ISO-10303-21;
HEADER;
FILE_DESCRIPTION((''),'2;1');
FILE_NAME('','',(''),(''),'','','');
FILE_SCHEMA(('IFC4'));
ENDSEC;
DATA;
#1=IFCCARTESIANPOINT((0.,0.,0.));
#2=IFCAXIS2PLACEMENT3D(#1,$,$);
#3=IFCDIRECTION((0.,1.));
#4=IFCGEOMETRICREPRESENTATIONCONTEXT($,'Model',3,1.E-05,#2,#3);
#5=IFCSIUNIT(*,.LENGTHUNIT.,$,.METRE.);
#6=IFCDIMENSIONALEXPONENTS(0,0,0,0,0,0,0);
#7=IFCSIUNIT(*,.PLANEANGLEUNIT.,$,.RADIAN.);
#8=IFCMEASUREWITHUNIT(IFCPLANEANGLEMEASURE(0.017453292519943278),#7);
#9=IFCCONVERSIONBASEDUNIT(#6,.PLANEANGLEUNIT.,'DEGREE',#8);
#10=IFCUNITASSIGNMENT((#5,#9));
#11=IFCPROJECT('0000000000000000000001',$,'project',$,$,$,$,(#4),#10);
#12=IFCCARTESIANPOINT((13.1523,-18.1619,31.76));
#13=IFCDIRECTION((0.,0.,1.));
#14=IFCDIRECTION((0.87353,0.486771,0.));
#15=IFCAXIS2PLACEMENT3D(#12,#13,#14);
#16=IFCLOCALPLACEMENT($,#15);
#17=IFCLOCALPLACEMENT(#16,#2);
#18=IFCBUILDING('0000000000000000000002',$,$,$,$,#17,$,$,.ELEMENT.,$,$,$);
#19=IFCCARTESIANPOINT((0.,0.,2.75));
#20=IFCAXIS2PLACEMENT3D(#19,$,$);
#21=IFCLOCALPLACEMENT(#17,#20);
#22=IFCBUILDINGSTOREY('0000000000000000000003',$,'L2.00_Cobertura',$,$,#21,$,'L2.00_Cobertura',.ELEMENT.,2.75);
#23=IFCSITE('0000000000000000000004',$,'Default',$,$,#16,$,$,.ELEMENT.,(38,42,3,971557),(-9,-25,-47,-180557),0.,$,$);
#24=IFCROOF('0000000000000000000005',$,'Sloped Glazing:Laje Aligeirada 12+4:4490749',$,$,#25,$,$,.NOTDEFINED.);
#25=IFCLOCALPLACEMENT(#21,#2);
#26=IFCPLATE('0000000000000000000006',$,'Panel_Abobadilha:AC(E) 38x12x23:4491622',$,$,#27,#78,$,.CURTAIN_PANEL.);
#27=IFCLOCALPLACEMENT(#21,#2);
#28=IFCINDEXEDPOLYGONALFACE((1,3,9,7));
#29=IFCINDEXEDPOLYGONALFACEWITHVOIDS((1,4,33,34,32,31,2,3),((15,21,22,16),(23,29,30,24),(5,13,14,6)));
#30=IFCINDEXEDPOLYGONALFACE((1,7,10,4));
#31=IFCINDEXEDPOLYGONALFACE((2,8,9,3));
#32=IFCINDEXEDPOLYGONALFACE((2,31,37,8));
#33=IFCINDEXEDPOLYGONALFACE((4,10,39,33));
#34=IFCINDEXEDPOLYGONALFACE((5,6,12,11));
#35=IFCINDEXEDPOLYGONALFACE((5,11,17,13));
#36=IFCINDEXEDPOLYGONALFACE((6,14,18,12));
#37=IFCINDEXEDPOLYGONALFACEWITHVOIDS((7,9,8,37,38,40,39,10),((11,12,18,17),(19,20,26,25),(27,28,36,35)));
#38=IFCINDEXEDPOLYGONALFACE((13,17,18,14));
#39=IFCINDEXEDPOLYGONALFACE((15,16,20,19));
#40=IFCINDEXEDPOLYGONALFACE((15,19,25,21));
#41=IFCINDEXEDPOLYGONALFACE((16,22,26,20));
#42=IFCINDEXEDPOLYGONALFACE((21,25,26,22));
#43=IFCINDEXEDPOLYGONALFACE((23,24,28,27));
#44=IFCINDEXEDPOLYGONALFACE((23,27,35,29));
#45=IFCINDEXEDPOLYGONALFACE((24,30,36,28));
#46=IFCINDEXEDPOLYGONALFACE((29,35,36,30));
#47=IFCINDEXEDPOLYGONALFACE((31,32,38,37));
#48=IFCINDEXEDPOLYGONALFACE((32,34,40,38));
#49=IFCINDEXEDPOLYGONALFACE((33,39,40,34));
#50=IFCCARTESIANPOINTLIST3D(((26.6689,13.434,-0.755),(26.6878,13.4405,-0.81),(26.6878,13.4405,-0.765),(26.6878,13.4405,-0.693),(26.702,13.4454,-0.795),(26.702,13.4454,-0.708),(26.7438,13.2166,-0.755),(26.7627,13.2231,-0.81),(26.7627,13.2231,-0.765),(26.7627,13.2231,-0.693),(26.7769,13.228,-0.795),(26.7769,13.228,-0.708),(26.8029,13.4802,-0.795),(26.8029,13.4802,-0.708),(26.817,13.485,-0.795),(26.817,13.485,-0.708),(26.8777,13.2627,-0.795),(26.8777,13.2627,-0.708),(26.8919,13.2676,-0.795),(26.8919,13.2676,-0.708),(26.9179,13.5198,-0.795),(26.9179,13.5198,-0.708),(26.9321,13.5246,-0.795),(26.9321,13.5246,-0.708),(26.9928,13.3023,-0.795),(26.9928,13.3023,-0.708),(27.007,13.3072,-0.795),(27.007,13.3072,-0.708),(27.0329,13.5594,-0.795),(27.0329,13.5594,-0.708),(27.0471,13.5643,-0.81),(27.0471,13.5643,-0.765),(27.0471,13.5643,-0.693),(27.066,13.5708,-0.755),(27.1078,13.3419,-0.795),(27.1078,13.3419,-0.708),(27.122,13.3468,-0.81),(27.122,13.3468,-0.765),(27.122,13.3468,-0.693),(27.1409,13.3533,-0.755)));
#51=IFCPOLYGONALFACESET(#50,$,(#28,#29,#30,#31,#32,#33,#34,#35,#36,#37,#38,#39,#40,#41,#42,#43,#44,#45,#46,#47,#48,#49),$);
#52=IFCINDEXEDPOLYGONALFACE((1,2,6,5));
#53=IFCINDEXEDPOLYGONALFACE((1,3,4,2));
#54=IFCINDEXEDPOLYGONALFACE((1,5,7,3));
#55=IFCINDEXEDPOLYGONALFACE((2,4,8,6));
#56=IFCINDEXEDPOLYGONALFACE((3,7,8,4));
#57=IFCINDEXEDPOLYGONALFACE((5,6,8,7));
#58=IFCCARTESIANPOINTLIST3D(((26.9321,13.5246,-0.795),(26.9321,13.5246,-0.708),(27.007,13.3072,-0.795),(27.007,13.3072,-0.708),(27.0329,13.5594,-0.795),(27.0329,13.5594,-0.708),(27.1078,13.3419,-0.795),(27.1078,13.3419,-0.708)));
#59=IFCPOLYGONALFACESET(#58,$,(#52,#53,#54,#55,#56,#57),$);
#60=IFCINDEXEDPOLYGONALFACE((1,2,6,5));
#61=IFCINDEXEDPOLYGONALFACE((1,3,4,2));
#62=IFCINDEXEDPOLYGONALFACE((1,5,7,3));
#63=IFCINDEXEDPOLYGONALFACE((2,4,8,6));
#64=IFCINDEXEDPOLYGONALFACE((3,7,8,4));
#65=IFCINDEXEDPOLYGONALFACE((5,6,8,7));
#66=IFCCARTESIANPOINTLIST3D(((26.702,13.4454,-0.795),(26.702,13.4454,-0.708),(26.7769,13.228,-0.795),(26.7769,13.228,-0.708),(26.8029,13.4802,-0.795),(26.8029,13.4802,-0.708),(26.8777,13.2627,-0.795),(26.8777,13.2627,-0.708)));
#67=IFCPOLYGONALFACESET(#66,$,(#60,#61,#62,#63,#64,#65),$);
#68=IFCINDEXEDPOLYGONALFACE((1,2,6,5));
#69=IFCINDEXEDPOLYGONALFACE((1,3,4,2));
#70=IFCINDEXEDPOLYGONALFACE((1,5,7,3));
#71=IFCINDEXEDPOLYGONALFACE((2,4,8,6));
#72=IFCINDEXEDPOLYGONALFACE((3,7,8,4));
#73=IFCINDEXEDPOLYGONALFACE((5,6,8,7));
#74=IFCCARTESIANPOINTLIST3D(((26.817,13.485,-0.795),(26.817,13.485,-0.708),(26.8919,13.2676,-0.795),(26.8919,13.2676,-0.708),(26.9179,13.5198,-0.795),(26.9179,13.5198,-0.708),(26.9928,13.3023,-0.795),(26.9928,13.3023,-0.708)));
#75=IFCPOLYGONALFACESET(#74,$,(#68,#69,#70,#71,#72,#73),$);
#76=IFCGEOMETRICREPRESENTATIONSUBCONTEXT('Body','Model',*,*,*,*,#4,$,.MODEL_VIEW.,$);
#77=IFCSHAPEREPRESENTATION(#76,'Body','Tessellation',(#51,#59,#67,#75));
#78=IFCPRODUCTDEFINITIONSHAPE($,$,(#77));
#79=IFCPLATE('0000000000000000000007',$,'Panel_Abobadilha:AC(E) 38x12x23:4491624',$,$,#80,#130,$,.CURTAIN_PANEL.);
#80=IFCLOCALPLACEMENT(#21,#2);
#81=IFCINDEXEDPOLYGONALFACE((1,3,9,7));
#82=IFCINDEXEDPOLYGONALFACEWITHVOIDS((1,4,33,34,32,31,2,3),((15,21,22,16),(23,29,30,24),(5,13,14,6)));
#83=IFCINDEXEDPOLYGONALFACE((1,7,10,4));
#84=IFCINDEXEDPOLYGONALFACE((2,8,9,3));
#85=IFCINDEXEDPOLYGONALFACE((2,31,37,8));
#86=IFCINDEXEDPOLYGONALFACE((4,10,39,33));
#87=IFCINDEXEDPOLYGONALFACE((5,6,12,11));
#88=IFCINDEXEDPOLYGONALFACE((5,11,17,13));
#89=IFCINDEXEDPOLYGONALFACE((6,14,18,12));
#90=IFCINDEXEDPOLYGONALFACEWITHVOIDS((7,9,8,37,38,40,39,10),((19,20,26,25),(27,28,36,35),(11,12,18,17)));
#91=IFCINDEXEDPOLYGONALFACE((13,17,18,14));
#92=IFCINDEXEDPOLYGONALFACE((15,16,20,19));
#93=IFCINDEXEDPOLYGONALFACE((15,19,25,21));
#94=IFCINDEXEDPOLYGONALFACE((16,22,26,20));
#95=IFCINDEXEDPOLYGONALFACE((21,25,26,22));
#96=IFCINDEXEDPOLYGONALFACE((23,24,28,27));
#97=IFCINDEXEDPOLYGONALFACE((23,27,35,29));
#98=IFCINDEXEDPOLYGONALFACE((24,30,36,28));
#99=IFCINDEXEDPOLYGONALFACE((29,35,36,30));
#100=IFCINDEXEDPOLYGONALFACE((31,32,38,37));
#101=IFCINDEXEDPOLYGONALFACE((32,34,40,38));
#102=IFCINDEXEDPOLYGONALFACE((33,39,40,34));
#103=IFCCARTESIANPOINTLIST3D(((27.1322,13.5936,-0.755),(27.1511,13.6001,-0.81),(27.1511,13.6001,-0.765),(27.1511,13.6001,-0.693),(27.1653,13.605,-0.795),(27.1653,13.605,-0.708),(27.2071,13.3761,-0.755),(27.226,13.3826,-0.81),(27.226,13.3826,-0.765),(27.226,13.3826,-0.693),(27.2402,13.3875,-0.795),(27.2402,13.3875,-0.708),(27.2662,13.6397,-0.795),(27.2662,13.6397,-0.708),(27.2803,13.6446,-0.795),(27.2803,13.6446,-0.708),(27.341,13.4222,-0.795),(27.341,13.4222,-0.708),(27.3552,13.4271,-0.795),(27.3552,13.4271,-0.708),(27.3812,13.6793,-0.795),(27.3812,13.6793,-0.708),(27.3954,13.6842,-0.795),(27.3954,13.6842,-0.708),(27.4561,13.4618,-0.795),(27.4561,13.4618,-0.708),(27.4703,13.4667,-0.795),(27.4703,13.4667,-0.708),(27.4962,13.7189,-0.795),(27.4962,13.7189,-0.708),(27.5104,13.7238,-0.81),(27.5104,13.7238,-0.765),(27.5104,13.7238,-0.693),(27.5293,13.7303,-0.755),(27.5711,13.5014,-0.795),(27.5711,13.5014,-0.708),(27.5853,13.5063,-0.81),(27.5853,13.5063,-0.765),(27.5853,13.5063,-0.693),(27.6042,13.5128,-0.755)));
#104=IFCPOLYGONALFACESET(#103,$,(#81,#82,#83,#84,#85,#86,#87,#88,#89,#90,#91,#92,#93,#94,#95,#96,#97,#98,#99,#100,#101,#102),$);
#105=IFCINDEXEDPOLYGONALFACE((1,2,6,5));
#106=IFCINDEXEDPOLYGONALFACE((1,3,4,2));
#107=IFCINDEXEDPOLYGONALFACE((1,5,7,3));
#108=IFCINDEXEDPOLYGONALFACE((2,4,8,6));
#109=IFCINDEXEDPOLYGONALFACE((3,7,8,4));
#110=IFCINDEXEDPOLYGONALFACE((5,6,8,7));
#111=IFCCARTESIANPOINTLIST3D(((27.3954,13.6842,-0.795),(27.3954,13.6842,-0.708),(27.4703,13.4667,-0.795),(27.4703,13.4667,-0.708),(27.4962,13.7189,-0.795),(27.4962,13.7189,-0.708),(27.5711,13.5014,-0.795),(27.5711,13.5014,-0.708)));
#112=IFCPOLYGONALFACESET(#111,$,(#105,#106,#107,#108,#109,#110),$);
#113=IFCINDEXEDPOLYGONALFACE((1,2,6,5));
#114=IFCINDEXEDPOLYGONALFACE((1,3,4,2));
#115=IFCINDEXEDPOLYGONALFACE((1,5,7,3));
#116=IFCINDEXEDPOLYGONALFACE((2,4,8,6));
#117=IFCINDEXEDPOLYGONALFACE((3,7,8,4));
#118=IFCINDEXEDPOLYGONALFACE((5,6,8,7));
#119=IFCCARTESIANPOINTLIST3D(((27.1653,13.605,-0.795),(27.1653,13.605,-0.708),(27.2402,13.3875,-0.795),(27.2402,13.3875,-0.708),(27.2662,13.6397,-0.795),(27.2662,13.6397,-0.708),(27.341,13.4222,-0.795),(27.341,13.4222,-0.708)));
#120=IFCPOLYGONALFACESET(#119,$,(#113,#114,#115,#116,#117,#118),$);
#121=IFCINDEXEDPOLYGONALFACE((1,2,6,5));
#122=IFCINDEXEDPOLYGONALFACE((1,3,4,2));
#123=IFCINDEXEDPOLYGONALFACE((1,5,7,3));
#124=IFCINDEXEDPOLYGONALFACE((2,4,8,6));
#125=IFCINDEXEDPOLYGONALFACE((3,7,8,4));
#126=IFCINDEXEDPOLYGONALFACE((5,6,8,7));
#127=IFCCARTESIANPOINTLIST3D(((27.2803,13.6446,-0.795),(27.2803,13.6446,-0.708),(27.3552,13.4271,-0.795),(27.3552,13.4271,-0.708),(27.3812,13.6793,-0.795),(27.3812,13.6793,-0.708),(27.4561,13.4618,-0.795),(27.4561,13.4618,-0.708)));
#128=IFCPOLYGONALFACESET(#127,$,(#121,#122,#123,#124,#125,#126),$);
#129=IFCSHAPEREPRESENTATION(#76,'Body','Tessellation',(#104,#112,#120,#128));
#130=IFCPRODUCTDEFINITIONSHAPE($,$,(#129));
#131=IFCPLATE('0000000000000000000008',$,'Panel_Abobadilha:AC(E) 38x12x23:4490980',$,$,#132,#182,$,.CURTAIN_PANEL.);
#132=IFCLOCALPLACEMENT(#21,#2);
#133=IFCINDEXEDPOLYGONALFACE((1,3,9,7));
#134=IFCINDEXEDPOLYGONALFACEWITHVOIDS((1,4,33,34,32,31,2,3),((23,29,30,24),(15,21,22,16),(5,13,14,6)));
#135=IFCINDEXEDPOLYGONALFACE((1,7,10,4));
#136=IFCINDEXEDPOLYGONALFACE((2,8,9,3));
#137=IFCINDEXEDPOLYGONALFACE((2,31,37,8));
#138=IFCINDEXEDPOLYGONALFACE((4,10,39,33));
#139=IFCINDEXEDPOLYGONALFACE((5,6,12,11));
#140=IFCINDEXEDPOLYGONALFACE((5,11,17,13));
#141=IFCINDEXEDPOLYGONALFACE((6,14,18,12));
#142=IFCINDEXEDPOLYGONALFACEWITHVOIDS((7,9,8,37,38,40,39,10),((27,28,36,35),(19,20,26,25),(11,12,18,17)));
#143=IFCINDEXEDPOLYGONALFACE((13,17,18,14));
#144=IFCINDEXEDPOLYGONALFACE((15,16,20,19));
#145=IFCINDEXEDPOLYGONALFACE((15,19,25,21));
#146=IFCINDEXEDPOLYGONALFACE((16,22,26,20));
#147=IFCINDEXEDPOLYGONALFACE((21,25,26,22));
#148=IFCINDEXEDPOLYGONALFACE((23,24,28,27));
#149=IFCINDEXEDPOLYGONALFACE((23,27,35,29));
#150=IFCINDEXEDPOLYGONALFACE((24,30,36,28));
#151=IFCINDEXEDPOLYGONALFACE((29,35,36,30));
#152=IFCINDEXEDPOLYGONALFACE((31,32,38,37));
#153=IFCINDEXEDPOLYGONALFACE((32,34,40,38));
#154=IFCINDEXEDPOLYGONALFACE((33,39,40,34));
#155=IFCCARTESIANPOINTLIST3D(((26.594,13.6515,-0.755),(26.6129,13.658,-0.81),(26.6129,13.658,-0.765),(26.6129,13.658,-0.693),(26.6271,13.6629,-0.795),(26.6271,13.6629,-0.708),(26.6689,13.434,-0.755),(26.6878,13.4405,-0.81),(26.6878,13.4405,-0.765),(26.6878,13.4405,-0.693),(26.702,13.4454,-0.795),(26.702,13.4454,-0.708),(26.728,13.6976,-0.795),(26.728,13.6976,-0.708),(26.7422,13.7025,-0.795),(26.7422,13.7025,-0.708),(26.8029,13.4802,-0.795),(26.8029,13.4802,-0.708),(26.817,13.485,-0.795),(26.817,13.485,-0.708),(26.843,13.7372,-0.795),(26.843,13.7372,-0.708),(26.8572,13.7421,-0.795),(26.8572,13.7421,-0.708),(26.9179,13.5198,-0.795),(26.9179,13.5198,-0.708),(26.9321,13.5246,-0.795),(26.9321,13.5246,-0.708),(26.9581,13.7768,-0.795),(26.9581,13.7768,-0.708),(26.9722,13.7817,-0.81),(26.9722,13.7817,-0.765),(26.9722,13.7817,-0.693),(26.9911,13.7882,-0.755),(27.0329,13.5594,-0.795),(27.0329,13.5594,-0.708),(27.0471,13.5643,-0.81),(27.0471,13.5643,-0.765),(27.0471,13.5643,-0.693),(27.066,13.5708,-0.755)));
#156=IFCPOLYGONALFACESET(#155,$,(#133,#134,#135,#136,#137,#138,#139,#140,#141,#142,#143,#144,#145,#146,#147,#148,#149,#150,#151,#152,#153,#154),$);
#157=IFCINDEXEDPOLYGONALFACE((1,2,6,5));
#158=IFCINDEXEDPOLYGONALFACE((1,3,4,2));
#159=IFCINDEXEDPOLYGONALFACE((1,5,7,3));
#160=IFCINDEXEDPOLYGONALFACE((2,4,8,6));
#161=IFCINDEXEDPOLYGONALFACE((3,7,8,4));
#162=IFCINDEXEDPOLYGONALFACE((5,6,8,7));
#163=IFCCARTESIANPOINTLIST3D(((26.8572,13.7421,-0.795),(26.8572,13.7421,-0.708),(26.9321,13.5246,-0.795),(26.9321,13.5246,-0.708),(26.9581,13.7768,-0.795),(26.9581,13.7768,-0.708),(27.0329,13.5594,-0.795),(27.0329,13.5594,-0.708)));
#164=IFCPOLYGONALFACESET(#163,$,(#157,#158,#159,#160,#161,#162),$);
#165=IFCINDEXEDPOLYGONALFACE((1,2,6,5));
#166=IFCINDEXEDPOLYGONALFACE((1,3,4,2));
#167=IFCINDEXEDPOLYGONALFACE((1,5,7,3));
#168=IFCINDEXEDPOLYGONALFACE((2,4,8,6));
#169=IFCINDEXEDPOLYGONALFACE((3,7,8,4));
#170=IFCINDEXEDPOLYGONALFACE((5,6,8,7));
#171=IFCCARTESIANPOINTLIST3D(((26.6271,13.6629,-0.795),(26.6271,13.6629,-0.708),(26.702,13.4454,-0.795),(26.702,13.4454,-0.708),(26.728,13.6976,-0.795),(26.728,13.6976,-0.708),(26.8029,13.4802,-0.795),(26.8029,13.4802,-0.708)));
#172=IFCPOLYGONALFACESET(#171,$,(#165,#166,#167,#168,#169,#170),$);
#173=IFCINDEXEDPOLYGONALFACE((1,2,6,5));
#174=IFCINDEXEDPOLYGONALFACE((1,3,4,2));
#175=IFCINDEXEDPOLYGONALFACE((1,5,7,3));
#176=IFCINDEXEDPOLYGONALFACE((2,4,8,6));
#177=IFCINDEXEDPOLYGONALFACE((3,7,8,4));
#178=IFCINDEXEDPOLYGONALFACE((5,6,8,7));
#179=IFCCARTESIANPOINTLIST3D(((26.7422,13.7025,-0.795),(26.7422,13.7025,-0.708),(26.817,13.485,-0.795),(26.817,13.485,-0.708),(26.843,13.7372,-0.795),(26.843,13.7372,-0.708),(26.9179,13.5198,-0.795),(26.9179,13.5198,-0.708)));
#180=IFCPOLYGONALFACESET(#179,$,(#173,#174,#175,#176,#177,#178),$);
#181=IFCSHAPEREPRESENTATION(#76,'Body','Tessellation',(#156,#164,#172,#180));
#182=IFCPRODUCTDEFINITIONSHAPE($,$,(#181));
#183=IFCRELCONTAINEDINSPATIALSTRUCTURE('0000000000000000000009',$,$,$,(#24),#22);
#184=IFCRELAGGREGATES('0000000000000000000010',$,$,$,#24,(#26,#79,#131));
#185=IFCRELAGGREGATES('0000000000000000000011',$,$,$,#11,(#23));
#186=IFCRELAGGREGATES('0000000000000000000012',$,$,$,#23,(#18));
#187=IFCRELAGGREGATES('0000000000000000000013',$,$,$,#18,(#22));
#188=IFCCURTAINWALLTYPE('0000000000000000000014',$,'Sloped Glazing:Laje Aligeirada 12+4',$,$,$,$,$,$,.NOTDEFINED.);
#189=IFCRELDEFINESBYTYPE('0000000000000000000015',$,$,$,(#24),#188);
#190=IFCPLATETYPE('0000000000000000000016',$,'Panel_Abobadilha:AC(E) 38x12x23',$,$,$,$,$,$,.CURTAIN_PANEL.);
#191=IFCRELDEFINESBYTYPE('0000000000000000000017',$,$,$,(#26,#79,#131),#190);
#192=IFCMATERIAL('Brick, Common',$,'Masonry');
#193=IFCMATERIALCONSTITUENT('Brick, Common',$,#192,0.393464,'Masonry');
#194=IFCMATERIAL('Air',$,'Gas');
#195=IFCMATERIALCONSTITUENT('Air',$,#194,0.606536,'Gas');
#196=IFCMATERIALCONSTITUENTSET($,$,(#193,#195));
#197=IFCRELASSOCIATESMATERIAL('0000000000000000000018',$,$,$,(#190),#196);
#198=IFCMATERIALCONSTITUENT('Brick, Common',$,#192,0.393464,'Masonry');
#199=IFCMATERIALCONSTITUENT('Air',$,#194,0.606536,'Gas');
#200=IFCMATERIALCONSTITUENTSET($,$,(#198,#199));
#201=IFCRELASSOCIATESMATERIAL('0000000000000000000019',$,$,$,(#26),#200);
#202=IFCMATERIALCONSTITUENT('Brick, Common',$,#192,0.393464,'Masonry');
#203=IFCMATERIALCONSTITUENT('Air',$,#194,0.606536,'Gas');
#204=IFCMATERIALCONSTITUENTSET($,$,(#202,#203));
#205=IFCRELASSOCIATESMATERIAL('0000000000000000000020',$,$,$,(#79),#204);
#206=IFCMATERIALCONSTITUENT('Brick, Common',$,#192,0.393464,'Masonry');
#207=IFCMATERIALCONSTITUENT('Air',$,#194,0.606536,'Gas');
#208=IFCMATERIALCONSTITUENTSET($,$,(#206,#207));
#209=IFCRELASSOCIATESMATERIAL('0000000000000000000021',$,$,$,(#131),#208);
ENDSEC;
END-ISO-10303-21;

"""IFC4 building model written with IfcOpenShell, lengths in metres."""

from ifc_helpers import new_model, entity, si_unit, converted_unit, direction, frame, origin, place, context, subcontext, project, spatial, indexed_curve, outline, extrude, source, transform, mapped, material, constituent, constituent_set, type_object, type_shapes, element, aggregate, save


model = new_model("IFC4")

# Units and contexts
model_context = context("Model", 3, precision=1e-05, world=origin(), true_north=direction((0.0, 1.0)))
body_context = subcontext(model_context, "Body", "Model", "MODEL_VIEW")
ifc_project = project(units=[si_unit("LENGTHUNIT", "METRE"), converted_unit("PLANEANGLEUNIT", "DEGREE", entity("IfcPlaneAngleMeasure", 0.017453292519943278), si_unit("PLANEANGLEUNIT", "RADIAN"), dimensions=[0, 0, 0, 0, 0, 0, 0])], contexts=[model_context])

# Site, building, storey
site_placement = place(None, frame((13.1523, -18.1619, 31.76), z_axis=(0.0, 0.0, 1.0), x_axis=(0.87353, 0.486771, 0.0)))
site = spatial("IfcSite", under=ifc_project, at=site_placement, Name="Default", CompositionType="ELEMENT", RefLatitude=(38, 42, 3, 971557), RefLongitude=(-9, -25, -47, -180557), RefElevation=0.0)
building_placement = place(site_placement, origin())
building = spatial("IfcBuilding", under=site, at=building_placement, CompositionType="ELEMENT")
storey_placement = place(building_placement, frame((0.0, 0.0, 2.75)))
storey = spatial("IfcBuildingStorey", under=building, at=storey_placement, Name="L2.00_Cobertura", LongName="L2.00_Cobertura", CompositionType="ELEMENT", Elevation=2.75)

# Roof, plates
curtain_wall_type = type_object("IfcCurtainWallType", Name="Sloped Glazing:Laje Aligeirada 12+4", PredefinedType="NOTDEFINED")
roof_placement = place(storey_placement, frame((0.0, 0.0, -2.75)))
roof = element("IfcRoof", 1, at=roof_placement, inside=storey, type_object=curtain_wall_type, Name="Sloped Glazing:Laje Aligeirada 12+4:4490749", PredefinedType="NOTDEFINED")
ifc_material_1 = material(Name="Brick, Common", Category="Masonry")
ifc_material_2 = material(Name="Air", Category="Gas")
ifc_constituent_1 = constituent(ifc_material_1, Name="Brick, Common", Category="Masonry", fraction=0.393464)
ifc_constituent_2 = constituent(ifc_material_2, Name="Air", Category="Gas", fraction=0.606536)
ifc_constituent_set_1 = constituent_set(constituents=[ifc_constituent_1, ifc_constituent_2])
plate_type = type_object("IfcPlateType", Name="Panel_Abobadilha:AC(E) 38x12x23", PredefinedType="CURTAIN_PANEL", material=ifc_constituent_set_1)
shared_shape_1 = source(origin(), body_context, "Body", "SweptSolid", [
    extrude(outline(indexed_curve([(-0.19, -0.0543), (0.19, -0.0543), (0.19, -0.0093), (0.21, 0.0007), (0.19, 0.0628), (-0.19, 0.0628), (-0.21, 0.0007), (-0.19, -0.0093), (-0.19, -0.0543)], self_intersect=False), holes=[indexed_curve([(-0.0683, 0.0477), (-0.0683, -0.0393), (-0.175, -0.0393), (-0.175, 0.0477), (-0.0683, 0.0477)], self_intersect=False), indexed_curve([(0.0533, 0.0477), (0.0533, -0.0393), (-0.0533, -0.0393), (-0.0533, 0.0477), (0.0533, 0.0477)], self_intersect=False), indexed_curve([(0.175, 0.0477), (0.175, -0.0393), (0.0683, -0.0393), (0.0683, 0.0477), (0.175, 0.0477)], self_intersect=False)]), frame((0.0, 0.0543, 0.0)), (0.0, 0.0, 1.0), 0.23),
    extrude(outline(indexed_curve([(-0.0533, -0.0435), (0.0533, -0.0435), (0.0533, 0.0435), (-0.0533, 0.0435), (-0.0533, -0.0435)], self_intersect=False)), frame((0.1217, 0.0585, 0.0), z_axis=(0.0, 0.0, 1.0), x_axis=(-1.0, 0.0, 0.0)), (0.0, 0.0, 1.0), 0.23),
    extrude(outline(indexed_curve([(-0.0533, -0.0435), (0.0533, -0.0435), (0.0533, 0.0435), (-0.0533, 0.0435), (-0.0533, -0.0435)], self_intersect=False)), frame((-0.1217, 0.0585, 0.0), z_axis=(0.0, 0.0, 1.0), x_axis=(-1.0, 0.0, 0.0)), (0.0, 0.0, 1.0), 0.23),
    extrude(outline(indexed_curve([(-0.0533, -0.0435), (0.0533, -0.0435), (0.0533, 0.0435), (-0.0533, 0.0435), (-0.0533, -0.0435)], self_intersect=False)), frame((0.0, 0.0585, 0.0), z_axis=(0.0, 0.0, 1.0), x_axis=(-1.0, 0.0, 0.0)), (0.0, 0.0, 1.0), 0.23),
])
type_shapes(plate_type, [shared_shape_1])
ifc_constituent_3 = constituent(ifc_material_1, Name="Brick, Common", Category="Masonry", fraction=0.393464)
ifc_constituent_4 = constituent(ifc_material_2, Name="Air", Category="Gas", fraction=0.606536)
ifc_constituent_set_2 = constituent_set(constituents=[ifc_constituent_3, ifc_constituent_4])
plate_1_placement = place(roof_placement, frame((26.8675, 13.5024, 1.94), z_axis=(0.325568, -0.945519, 0.0), x_axis=(0.945519, 0.325568, 0.0)))
plate_1 = element("IfcPlate", 2, at=plate_1_placement, type_object=plate_type, material=ifc_constituent_set_2, Name="Panel_Abobadilha:AC(E) 38x12x23:4491622", PredefinedType="CURTAIN_PANEL", context=body_context, shape_type="MappedRepresentation", body=[
    mapped(shared_shape_1, transform((0.0, 0.0, 0.0), scale=1.0)),
])
ifc_constituent_5 = constituent(ifc_material_1, Name="Brick, Common", Category="Masonry", fraction=0.393464)
ifc_constituent_6 = constituent(ifc_material_2, Name="Air", Category="Gas", fraction=0.606536)
ifc_constituent_set_3 = constituent_set(constituents=[ifc_constituent_5, ifc_constituent_6])
plate_2_placement = place(roof_placement, frame((27.3308, 13.6619, 1.94), z_axis=(0.325568, -0.945519, 0.0), x_axis=(0.945519, 0.325568, 0.0)))
plate_2 = element("IfcPlate", 3, at=plate_2_placement, type_object=plate_type, material=ifc_constituent_set_3, Name="Panel_Abobadilha:AC(E) 38x12x23:4491624", PredefinedType="CURTAIN_PANEL", context=body_context, shape_type="MappedRepresentation", body=[
    mapped(shared_shape_1, transform((0.0, 0.0, 0.0), scale=1.0)),
])
ifc_constituent_7 = constituent(ifc_material_1, Name="Brick, Common", Category="Masonry", fraction=0.393464)
ifc_constituent_8 = constituent(ifc_material_2, Name="Air", Category="Gas", fraction=0.606536)
ifc_constituent_set_4 = constituent_set(constituents=[ifc_constituent_7, ifc_constituent_8])
plate_3_placement = place(roof_placement, frame((26.7926, 13.7199, 1.94), z_axis=(0.325568, -0.945519, 0.0), x_axis=(0.945519, 0.325568, 0.0)))
plate_3 = element("IfcPlate", 4, at=plate_3_placement, type_object=plate_type, material=ifc_constituent_set_4, Name="Panel_Abobadilha:AC(E) 38x12x23:4490980", PredefinedType="CURTAIN_PANEL", context=body_context, shape_type="MappedRepresentation", body=[
    mapped(shared_shape_1, transform((0.0, 0.0, 0.0), scale=1.0)),
])
aggregate(roof, [plate_1, plate_2, plate_3])

save(model, "model.ifc")
